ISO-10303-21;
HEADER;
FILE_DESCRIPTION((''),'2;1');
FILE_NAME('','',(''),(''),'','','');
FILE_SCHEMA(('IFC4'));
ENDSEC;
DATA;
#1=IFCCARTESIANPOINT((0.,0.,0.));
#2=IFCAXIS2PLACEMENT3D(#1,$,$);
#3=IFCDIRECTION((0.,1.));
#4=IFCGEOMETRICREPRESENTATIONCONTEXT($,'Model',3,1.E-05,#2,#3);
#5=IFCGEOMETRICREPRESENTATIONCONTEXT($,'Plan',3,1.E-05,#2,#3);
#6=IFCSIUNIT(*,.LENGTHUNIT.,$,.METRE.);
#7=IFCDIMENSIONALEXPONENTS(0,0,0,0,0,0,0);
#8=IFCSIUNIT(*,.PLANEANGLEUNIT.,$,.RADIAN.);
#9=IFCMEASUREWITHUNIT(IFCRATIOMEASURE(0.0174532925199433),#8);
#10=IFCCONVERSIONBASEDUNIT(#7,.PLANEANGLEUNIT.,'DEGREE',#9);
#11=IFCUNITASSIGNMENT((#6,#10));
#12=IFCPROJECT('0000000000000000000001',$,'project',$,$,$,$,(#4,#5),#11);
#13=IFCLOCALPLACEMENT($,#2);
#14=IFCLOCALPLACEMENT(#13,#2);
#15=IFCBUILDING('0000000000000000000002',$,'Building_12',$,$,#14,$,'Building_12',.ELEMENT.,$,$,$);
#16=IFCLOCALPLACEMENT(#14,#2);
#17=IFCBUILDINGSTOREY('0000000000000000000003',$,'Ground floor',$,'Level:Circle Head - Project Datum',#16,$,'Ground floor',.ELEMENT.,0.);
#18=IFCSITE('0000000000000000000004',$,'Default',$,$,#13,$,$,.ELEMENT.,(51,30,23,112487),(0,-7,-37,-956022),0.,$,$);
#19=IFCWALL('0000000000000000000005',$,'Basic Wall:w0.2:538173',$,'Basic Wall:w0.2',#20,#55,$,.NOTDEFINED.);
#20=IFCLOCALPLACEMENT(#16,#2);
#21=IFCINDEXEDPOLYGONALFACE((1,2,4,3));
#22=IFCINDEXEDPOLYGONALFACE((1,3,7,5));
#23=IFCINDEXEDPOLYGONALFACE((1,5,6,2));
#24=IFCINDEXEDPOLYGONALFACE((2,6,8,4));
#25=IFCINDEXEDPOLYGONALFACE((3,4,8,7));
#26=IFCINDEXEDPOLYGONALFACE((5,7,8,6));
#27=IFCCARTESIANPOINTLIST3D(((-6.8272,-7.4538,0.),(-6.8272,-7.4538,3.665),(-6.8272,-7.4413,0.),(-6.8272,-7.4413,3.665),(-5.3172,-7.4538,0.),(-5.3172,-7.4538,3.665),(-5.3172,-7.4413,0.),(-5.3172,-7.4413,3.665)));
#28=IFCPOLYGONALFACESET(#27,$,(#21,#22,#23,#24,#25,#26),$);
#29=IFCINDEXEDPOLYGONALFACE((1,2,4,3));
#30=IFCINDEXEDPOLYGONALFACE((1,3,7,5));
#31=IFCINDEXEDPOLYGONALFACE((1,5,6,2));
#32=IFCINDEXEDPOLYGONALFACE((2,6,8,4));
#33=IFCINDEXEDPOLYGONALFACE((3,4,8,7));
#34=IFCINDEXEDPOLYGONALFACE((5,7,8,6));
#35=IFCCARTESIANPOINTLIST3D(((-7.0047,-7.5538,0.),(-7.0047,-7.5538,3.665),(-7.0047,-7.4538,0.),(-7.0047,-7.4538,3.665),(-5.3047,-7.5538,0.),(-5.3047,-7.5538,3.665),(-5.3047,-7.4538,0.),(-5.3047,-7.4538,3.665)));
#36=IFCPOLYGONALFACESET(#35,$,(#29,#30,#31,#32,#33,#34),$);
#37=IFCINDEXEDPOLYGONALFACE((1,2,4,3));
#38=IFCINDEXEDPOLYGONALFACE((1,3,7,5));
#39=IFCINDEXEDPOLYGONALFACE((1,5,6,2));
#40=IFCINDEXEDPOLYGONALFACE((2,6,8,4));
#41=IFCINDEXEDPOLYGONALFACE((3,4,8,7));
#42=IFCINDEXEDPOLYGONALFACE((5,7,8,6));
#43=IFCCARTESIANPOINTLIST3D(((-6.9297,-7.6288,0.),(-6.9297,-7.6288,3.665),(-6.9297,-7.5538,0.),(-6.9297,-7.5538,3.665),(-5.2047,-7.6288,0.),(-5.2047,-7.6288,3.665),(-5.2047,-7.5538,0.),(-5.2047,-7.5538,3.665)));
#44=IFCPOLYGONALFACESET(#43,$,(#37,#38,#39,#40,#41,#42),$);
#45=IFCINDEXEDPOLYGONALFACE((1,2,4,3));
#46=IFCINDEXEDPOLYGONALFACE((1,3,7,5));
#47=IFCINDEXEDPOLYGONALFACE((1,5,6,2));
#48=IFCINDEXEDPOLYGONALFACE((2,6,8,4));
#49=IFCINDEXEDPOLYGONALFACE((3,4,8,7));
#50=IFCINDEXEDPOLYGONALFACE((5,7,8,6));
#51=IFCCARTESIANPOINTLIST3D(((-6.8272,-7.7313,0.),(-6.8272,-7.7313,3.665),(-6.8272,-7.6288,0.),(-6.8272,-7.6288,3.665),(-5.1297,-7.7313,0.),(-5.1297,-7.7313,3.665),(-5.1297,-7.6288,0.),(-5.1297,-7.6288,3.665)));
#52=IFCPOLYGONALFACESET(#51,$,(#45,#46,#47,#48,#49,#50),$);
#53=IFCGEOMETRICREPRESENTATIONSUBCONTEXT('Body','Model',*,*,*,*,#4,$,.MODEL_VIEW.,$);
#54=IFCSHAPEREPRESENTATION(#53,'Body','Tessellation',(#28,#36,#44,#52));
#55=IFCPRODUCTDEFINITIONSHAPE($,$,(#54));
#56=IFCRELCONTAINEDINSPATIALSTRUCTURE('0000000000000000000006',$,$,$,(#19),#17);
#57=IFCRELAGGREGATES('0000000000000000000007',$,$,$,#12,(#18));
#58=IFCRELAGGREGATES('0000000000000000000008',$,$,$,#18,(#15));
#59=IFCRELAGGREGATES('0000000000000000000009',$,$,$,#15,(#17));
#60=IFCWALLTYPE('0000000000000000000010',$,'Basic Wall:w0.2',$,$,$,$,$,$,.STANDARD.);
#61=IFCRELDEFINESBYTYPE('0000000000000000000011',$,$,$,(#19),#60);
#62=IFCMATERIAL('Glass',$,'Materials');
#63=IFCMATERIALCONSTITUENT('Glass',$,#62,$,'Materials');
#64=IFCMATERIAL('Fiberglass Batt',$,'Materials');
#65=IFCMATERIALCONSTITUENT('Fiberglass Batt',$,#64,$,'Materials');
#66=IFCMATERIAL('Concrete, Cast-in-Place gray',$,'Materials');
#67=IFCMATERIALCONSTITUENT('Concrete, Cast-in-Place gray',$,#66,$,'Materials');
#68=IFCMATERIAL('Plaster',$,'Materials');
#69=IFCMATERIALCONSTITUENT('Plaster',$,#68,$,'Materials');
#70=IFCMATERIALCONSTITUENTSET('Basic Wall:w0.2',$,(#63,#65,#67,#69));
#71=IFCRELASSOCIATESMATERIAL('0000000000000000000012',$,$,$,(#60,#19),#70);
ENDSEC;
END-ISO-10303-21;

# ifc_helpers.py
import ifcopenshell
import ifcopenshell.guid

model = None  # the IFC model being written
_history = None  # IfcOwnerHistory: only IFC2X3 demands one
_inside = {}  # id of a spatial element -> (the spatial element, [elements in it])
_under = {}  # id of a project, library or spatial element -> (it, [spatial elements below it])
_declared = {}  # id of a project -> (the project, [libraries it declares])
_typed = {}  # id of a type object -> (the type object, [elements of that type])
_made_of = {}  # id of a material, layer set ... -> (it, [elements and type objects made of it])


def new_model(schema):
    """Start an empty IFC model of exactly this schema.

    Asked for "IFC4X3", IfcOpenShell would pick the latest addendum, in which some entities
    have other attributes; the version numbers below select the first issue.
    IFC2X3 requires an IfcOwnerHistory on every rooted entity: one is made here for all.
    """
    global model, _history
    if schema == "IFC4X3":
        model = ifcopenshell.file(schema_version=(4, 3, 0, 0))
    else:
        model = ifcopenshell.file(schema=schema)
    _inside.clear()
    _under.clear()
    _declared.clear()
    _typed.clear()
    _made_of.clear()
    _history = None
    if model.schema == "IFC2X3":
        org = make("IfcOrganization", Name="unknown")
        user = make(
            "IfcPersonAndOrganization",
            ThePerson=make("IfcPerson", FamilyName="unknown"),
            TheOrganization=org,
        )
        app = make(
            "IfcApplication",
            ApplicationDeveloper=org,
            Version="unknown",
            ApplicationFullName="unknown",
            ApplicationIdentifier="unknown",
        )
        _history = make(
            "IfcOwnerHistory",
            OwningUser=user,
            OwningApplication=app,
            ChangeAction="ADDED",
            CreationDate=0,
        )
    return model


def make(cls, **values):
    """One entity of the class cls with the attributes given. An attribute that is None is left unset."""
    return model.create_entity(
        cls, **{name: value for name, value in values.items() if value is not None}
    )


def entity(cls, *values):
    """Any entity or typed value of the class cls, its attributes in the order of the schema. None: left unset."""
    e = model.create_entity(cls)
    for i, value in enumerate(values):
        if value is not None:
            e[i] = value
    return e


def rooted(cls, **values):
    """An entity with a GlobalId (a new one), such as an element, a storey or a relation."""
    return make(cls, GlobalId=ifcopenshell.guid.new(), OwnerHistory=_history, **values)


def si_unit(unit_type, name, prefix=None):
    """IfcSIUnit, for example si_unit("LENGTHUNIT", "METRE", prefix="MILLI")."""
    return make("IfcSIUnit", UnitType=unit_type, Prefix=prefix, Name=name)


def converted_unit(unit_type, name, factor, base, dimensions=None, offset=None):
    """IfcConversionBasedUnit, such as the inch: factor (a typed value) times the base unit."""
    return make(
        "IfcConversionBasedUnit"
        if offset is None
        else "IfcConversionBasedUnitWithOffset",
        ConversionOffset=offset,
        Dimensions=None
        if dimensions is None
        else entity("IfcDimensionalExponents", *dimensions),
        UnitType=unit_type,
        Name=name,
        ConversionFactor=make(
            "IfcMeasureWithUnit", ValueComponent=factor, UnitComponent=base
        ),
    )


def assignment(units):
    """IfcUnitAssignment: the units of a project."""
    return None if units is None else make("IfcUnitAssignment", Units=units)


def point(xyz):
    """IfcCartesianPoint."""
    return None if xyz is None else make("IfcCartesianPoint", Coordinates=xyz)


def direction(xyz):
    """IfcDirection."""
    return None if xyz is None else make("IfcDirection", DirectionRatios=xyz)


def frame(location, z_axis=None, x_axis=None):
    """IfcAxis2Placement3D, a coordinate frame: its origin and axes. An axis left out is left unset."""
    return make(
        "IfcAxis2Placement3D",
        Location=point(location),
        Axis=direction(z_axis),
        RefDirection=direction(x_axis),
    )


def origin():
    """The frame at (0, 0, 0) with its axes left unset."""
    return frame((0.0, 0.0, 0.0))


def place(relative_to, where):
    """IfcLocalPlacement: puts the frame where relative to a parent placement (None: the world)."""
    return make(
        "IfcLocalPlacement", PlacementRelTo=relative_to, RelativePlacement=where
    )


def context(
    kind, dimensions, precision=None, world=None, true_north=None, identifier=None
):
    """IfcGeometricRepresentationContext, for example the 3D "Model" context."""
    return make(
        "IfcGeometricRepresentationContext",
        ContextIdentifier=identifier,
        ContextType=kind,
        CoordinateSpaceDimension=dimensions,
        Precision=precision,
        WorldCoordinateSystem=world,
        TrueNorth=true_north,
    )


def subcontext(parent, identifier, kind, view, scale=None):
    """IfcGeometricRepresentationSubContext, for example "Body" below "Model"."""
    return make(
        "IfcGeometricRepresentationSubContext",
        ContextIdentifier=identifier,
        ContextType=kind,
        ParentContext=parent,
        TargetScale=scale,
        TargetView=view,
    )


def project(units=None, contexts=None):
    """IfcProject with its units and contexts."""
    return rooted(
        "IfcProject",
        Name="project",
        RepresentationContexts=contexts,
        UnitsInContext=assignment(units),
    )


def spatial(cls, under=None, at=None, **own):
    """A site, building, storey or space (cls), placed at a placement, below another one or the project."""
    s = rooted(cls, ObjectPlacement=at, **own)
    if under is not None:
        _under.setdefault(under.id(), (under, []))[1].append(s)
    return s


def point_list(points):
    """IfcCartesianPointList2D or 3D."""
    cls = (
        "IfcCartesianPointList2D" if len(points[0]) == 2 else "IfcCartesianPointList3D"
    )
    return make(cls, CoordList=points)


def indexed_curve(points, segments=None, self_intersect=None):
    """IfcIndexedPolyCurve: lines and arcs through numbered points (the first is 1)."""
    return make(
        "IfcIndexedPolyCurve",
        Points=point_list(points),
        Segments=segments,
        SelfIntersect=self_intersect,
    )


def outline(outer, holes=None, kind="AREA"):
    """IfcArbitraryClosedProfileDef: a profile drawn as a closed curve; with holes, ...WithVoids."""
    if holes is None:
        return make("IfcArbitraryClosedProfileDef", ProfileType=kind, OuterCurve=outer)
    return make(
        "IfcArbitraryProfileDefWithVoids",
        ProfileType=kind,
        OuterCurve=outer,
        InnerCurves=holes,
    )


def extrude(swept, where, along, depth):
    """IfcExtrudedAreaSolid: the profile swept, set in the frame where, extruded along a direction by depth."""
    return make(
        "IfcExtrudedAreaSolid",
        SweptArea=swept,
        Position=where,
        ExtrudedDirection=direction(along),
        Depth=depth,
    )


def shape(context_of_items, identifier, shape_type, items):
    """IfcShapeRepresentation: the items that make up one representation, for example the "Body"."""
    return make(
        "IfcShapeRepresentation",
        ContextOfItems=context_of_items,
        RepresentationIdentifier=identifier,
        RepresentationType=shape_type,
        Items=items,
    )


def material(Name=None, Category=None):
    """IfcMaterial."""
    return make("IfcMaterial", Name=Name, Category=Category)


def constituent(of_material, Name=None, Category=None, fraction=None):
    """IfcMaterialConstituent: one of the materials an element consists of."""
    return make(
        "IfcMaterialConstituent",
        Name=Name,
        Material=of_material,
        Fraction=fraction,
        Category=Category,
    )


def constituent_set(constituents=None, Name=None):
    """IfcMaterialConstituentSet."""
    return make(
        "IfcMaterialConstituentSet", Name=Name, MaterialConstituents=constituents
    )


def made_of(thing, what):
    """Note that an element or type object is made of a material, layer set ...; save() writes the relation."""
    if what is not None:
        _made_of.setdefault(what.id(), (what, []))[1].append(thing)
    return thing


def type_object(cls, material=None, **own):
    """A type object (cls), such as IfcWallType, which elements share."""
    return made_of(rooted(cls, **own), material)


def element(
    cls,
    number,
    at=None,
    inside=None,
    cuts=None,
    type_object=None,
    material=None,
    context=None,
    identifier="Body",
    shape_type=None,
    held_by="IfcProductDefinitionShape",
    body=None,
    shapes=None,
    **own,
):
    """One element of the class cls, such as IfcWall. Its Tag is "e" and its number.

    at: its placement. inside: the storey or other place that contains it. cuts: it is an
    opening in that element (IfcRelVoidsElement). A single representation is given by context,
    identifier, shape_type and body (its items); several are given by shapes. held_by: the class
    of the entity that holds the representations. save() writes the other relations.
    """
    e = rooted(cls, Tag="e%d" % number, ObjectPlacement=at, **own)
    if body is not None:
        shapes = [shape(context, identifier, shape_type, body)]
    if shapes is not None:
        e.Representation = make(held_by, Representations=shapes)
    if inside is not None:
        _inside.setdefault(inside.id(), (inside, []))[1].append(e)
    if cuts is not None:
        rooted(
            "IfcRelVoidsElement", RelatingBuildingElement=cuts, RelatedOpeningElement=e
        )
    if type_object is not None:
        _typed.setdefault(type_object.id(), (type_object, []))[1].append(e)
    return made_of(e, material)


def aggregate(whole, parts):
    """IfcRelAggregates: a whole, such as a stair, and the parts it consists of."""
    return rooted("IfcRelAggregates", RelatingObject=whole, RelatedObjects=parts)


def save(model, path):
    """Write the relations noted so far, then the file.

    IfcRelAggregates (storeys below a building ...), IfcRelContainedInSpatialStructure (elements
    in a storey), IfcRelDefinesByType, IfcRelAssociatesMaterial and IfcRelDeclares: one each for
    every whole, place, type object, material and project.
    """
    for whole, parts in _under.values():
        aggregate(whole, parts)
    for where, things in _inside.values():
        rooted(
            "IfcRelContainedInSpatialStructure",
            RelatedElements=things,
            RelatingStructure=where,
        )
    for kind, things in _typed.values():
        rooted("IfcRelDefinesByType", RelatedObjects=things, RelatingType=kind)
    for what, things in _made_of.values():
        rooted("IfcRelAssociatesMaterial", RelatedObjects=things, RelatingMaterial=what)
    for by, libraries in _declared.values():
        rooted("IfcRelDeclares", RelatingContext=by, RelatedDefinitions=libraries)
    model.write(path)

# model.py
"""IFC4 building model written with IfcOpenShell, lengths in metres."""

from ifc_helpers import new_model, entity, si_unit, converted_unit, direction, frame, origin, place, context, subcontext, project, spatial, indexed_curve, outline, extrude, material, constituent, constituent_set, type_object, element, save


model = new_model("IFC4")

# Units and contexts
model_context = context("Model", 3, precision=1e-05, world=origin(), true_north=direction((0.0, 1.0)))
plan_context = context("Plan", 3, precision=1e-05, world=origin(), true_north=direction((0.0, 1.0)))
body_context = subcontext(model_context, "Body", "Model", "MODEL_VIEW")
ifc_project = project(units=[si_unit("LENGTHUNIT", "METRE"), converted_unit("PLANEANGLEUNIT", "DEGREE", entity("IfcRatioMeasure", 0.0174532925199433), si_unit("PLANEANGLEUNIT", "RADIAN"), dimensions=[0, 0, 0, 0, 0, 0, 0])], contexts=[model_context, plan_context])

# Site, building, storey
site_placement = place(None, origin())
site = spatial("IfcSite", under=ifc_project, at=site_placement, Name="Default", CompositionType="ELEMENT", RefLatitude=(51, 30, 23, 112487), RefLongitude=(0, -7, -37, -956022), RefElevation=0.0)
building_placement = place(site_placement, origin())
building = spatial("IfcBuilding", under=site, at=building_placement, Name="Building_12", LongName="Building_12", CompositionType="ELEMENT")
storey_placement = place(building_placement, origin())
storey = spatial("IfcBuildingStorey", under=building, at=storey_placement, Name="Ground floor", ObjectType="Level:Circle Head - Project Datum", LongName="Ground floor", CompositionType="ELEMENT", Elevation=0.0)

# Shared definitions
ifc_material_1 = material(Name="Plaster", Category="Materials")
ifc_material_2 = material(Name="Glass", Category="Materials")

# Shared definitions
ifc_material_3 = material(Name="Concrete, Cast-in-Place gray", Category="Materials")

# Shared definitions
ifc_constituent_1 = constituent(ifc_material_2, Name="Glass", Category="Materials")
ifc_material_4 = material(Name="Fiberglass Batt", Category="Materials")
ifc_constituent_2 = constituent(ifc_material_4, Name="Fiberglass Batt", Category="Materials")
ifc_constituent_3 = constituent(ifc_material_3, Name="Concrete, Cast-in-Place gray", Category="Materials")
ifc_constituent_4 = constituent(ifc_material_1, Name="Plaster", Category="Materials")
ifc_constituent_set_1 = constituent_set(constituents=[ifc_constituent_1, ifc_constituent_2, ifc_constituent_3, ifc_constituent_4], Name="Basic Wall:w0.2")
wall_type = type_object("IfcWallType", Name="Basic Wall:w0.2", PredefinedType="STANDARD", material=ifc_constituent_set_1)

# Wall
wall_1_placement = place(storey_placement, frame((-5.3172, -7.5863, 0.0), z_axis=(0.0, 0.0, 1.0), x_axis=(-1.0, 0.0, 0.0)))
element("IfcWall", 1, at=wall_1_placement, inside=storey, type_object=wall_type, material=ifc_constituent_set_1, Name="Basic Wall:w0.2:538173", ObjectType="Basic Wall:w0.2", PredefinedType="NOTDEFINED", context=body_context, shape_type="SweptSolid", body=[
    extrude(outline(indexed_curve([(-0.0063, -0.755), (0.0062, -0.755), (0.0063, 0.755), (-0.0062, 0.755), (-0.0063, -0.755)], self_intersect=False)), frame((0.755, -0.1388, 0.0), z_axis=(0.0, 0.0, 1.0), x_axis=(0.0, 1.0, 0.0)), (0.0, 0.0, 1.0), 3.665),
    extrude(outline(indexed_curve([(-0.85, -0.05), (0.85, -0.05), (0.85, 0.05), (-0.85, 0.05), (-0.85, -0.05)], self_intersect=False)), frame((0.8375, -0.0825, 0.0)), (0.0, 0.0, 1.0), 3.665),
    extrude(outline(indexed_curve([(-0.8625, -0.0375), (0.8625, -0.0375), (0.8625, 0.0375), (-0.8625, 0.0375), (-0.8625, -0.0375)], self_intersect=False)), frame((0.75, 0.005, 0.0)), (0.0, 0.0, 1.0), 3.665),
    extrude(outline(indexed_curve([(-0.0513, -0.8487), (0.0512, -0.8487), (0.0513, 0.8487), (-0.0512, 0.8487), (-0.0513, -0.8487)], self_intersect=False)), frame((0.6612, 0.0938, 0.0), z_axis=(0.0, 0.0, 1.0), x_axis=(0.0, -1.0, 0.0)), (0.0, 0.0, 1.0), 3.665),
])

save(model, "model.ifc")
